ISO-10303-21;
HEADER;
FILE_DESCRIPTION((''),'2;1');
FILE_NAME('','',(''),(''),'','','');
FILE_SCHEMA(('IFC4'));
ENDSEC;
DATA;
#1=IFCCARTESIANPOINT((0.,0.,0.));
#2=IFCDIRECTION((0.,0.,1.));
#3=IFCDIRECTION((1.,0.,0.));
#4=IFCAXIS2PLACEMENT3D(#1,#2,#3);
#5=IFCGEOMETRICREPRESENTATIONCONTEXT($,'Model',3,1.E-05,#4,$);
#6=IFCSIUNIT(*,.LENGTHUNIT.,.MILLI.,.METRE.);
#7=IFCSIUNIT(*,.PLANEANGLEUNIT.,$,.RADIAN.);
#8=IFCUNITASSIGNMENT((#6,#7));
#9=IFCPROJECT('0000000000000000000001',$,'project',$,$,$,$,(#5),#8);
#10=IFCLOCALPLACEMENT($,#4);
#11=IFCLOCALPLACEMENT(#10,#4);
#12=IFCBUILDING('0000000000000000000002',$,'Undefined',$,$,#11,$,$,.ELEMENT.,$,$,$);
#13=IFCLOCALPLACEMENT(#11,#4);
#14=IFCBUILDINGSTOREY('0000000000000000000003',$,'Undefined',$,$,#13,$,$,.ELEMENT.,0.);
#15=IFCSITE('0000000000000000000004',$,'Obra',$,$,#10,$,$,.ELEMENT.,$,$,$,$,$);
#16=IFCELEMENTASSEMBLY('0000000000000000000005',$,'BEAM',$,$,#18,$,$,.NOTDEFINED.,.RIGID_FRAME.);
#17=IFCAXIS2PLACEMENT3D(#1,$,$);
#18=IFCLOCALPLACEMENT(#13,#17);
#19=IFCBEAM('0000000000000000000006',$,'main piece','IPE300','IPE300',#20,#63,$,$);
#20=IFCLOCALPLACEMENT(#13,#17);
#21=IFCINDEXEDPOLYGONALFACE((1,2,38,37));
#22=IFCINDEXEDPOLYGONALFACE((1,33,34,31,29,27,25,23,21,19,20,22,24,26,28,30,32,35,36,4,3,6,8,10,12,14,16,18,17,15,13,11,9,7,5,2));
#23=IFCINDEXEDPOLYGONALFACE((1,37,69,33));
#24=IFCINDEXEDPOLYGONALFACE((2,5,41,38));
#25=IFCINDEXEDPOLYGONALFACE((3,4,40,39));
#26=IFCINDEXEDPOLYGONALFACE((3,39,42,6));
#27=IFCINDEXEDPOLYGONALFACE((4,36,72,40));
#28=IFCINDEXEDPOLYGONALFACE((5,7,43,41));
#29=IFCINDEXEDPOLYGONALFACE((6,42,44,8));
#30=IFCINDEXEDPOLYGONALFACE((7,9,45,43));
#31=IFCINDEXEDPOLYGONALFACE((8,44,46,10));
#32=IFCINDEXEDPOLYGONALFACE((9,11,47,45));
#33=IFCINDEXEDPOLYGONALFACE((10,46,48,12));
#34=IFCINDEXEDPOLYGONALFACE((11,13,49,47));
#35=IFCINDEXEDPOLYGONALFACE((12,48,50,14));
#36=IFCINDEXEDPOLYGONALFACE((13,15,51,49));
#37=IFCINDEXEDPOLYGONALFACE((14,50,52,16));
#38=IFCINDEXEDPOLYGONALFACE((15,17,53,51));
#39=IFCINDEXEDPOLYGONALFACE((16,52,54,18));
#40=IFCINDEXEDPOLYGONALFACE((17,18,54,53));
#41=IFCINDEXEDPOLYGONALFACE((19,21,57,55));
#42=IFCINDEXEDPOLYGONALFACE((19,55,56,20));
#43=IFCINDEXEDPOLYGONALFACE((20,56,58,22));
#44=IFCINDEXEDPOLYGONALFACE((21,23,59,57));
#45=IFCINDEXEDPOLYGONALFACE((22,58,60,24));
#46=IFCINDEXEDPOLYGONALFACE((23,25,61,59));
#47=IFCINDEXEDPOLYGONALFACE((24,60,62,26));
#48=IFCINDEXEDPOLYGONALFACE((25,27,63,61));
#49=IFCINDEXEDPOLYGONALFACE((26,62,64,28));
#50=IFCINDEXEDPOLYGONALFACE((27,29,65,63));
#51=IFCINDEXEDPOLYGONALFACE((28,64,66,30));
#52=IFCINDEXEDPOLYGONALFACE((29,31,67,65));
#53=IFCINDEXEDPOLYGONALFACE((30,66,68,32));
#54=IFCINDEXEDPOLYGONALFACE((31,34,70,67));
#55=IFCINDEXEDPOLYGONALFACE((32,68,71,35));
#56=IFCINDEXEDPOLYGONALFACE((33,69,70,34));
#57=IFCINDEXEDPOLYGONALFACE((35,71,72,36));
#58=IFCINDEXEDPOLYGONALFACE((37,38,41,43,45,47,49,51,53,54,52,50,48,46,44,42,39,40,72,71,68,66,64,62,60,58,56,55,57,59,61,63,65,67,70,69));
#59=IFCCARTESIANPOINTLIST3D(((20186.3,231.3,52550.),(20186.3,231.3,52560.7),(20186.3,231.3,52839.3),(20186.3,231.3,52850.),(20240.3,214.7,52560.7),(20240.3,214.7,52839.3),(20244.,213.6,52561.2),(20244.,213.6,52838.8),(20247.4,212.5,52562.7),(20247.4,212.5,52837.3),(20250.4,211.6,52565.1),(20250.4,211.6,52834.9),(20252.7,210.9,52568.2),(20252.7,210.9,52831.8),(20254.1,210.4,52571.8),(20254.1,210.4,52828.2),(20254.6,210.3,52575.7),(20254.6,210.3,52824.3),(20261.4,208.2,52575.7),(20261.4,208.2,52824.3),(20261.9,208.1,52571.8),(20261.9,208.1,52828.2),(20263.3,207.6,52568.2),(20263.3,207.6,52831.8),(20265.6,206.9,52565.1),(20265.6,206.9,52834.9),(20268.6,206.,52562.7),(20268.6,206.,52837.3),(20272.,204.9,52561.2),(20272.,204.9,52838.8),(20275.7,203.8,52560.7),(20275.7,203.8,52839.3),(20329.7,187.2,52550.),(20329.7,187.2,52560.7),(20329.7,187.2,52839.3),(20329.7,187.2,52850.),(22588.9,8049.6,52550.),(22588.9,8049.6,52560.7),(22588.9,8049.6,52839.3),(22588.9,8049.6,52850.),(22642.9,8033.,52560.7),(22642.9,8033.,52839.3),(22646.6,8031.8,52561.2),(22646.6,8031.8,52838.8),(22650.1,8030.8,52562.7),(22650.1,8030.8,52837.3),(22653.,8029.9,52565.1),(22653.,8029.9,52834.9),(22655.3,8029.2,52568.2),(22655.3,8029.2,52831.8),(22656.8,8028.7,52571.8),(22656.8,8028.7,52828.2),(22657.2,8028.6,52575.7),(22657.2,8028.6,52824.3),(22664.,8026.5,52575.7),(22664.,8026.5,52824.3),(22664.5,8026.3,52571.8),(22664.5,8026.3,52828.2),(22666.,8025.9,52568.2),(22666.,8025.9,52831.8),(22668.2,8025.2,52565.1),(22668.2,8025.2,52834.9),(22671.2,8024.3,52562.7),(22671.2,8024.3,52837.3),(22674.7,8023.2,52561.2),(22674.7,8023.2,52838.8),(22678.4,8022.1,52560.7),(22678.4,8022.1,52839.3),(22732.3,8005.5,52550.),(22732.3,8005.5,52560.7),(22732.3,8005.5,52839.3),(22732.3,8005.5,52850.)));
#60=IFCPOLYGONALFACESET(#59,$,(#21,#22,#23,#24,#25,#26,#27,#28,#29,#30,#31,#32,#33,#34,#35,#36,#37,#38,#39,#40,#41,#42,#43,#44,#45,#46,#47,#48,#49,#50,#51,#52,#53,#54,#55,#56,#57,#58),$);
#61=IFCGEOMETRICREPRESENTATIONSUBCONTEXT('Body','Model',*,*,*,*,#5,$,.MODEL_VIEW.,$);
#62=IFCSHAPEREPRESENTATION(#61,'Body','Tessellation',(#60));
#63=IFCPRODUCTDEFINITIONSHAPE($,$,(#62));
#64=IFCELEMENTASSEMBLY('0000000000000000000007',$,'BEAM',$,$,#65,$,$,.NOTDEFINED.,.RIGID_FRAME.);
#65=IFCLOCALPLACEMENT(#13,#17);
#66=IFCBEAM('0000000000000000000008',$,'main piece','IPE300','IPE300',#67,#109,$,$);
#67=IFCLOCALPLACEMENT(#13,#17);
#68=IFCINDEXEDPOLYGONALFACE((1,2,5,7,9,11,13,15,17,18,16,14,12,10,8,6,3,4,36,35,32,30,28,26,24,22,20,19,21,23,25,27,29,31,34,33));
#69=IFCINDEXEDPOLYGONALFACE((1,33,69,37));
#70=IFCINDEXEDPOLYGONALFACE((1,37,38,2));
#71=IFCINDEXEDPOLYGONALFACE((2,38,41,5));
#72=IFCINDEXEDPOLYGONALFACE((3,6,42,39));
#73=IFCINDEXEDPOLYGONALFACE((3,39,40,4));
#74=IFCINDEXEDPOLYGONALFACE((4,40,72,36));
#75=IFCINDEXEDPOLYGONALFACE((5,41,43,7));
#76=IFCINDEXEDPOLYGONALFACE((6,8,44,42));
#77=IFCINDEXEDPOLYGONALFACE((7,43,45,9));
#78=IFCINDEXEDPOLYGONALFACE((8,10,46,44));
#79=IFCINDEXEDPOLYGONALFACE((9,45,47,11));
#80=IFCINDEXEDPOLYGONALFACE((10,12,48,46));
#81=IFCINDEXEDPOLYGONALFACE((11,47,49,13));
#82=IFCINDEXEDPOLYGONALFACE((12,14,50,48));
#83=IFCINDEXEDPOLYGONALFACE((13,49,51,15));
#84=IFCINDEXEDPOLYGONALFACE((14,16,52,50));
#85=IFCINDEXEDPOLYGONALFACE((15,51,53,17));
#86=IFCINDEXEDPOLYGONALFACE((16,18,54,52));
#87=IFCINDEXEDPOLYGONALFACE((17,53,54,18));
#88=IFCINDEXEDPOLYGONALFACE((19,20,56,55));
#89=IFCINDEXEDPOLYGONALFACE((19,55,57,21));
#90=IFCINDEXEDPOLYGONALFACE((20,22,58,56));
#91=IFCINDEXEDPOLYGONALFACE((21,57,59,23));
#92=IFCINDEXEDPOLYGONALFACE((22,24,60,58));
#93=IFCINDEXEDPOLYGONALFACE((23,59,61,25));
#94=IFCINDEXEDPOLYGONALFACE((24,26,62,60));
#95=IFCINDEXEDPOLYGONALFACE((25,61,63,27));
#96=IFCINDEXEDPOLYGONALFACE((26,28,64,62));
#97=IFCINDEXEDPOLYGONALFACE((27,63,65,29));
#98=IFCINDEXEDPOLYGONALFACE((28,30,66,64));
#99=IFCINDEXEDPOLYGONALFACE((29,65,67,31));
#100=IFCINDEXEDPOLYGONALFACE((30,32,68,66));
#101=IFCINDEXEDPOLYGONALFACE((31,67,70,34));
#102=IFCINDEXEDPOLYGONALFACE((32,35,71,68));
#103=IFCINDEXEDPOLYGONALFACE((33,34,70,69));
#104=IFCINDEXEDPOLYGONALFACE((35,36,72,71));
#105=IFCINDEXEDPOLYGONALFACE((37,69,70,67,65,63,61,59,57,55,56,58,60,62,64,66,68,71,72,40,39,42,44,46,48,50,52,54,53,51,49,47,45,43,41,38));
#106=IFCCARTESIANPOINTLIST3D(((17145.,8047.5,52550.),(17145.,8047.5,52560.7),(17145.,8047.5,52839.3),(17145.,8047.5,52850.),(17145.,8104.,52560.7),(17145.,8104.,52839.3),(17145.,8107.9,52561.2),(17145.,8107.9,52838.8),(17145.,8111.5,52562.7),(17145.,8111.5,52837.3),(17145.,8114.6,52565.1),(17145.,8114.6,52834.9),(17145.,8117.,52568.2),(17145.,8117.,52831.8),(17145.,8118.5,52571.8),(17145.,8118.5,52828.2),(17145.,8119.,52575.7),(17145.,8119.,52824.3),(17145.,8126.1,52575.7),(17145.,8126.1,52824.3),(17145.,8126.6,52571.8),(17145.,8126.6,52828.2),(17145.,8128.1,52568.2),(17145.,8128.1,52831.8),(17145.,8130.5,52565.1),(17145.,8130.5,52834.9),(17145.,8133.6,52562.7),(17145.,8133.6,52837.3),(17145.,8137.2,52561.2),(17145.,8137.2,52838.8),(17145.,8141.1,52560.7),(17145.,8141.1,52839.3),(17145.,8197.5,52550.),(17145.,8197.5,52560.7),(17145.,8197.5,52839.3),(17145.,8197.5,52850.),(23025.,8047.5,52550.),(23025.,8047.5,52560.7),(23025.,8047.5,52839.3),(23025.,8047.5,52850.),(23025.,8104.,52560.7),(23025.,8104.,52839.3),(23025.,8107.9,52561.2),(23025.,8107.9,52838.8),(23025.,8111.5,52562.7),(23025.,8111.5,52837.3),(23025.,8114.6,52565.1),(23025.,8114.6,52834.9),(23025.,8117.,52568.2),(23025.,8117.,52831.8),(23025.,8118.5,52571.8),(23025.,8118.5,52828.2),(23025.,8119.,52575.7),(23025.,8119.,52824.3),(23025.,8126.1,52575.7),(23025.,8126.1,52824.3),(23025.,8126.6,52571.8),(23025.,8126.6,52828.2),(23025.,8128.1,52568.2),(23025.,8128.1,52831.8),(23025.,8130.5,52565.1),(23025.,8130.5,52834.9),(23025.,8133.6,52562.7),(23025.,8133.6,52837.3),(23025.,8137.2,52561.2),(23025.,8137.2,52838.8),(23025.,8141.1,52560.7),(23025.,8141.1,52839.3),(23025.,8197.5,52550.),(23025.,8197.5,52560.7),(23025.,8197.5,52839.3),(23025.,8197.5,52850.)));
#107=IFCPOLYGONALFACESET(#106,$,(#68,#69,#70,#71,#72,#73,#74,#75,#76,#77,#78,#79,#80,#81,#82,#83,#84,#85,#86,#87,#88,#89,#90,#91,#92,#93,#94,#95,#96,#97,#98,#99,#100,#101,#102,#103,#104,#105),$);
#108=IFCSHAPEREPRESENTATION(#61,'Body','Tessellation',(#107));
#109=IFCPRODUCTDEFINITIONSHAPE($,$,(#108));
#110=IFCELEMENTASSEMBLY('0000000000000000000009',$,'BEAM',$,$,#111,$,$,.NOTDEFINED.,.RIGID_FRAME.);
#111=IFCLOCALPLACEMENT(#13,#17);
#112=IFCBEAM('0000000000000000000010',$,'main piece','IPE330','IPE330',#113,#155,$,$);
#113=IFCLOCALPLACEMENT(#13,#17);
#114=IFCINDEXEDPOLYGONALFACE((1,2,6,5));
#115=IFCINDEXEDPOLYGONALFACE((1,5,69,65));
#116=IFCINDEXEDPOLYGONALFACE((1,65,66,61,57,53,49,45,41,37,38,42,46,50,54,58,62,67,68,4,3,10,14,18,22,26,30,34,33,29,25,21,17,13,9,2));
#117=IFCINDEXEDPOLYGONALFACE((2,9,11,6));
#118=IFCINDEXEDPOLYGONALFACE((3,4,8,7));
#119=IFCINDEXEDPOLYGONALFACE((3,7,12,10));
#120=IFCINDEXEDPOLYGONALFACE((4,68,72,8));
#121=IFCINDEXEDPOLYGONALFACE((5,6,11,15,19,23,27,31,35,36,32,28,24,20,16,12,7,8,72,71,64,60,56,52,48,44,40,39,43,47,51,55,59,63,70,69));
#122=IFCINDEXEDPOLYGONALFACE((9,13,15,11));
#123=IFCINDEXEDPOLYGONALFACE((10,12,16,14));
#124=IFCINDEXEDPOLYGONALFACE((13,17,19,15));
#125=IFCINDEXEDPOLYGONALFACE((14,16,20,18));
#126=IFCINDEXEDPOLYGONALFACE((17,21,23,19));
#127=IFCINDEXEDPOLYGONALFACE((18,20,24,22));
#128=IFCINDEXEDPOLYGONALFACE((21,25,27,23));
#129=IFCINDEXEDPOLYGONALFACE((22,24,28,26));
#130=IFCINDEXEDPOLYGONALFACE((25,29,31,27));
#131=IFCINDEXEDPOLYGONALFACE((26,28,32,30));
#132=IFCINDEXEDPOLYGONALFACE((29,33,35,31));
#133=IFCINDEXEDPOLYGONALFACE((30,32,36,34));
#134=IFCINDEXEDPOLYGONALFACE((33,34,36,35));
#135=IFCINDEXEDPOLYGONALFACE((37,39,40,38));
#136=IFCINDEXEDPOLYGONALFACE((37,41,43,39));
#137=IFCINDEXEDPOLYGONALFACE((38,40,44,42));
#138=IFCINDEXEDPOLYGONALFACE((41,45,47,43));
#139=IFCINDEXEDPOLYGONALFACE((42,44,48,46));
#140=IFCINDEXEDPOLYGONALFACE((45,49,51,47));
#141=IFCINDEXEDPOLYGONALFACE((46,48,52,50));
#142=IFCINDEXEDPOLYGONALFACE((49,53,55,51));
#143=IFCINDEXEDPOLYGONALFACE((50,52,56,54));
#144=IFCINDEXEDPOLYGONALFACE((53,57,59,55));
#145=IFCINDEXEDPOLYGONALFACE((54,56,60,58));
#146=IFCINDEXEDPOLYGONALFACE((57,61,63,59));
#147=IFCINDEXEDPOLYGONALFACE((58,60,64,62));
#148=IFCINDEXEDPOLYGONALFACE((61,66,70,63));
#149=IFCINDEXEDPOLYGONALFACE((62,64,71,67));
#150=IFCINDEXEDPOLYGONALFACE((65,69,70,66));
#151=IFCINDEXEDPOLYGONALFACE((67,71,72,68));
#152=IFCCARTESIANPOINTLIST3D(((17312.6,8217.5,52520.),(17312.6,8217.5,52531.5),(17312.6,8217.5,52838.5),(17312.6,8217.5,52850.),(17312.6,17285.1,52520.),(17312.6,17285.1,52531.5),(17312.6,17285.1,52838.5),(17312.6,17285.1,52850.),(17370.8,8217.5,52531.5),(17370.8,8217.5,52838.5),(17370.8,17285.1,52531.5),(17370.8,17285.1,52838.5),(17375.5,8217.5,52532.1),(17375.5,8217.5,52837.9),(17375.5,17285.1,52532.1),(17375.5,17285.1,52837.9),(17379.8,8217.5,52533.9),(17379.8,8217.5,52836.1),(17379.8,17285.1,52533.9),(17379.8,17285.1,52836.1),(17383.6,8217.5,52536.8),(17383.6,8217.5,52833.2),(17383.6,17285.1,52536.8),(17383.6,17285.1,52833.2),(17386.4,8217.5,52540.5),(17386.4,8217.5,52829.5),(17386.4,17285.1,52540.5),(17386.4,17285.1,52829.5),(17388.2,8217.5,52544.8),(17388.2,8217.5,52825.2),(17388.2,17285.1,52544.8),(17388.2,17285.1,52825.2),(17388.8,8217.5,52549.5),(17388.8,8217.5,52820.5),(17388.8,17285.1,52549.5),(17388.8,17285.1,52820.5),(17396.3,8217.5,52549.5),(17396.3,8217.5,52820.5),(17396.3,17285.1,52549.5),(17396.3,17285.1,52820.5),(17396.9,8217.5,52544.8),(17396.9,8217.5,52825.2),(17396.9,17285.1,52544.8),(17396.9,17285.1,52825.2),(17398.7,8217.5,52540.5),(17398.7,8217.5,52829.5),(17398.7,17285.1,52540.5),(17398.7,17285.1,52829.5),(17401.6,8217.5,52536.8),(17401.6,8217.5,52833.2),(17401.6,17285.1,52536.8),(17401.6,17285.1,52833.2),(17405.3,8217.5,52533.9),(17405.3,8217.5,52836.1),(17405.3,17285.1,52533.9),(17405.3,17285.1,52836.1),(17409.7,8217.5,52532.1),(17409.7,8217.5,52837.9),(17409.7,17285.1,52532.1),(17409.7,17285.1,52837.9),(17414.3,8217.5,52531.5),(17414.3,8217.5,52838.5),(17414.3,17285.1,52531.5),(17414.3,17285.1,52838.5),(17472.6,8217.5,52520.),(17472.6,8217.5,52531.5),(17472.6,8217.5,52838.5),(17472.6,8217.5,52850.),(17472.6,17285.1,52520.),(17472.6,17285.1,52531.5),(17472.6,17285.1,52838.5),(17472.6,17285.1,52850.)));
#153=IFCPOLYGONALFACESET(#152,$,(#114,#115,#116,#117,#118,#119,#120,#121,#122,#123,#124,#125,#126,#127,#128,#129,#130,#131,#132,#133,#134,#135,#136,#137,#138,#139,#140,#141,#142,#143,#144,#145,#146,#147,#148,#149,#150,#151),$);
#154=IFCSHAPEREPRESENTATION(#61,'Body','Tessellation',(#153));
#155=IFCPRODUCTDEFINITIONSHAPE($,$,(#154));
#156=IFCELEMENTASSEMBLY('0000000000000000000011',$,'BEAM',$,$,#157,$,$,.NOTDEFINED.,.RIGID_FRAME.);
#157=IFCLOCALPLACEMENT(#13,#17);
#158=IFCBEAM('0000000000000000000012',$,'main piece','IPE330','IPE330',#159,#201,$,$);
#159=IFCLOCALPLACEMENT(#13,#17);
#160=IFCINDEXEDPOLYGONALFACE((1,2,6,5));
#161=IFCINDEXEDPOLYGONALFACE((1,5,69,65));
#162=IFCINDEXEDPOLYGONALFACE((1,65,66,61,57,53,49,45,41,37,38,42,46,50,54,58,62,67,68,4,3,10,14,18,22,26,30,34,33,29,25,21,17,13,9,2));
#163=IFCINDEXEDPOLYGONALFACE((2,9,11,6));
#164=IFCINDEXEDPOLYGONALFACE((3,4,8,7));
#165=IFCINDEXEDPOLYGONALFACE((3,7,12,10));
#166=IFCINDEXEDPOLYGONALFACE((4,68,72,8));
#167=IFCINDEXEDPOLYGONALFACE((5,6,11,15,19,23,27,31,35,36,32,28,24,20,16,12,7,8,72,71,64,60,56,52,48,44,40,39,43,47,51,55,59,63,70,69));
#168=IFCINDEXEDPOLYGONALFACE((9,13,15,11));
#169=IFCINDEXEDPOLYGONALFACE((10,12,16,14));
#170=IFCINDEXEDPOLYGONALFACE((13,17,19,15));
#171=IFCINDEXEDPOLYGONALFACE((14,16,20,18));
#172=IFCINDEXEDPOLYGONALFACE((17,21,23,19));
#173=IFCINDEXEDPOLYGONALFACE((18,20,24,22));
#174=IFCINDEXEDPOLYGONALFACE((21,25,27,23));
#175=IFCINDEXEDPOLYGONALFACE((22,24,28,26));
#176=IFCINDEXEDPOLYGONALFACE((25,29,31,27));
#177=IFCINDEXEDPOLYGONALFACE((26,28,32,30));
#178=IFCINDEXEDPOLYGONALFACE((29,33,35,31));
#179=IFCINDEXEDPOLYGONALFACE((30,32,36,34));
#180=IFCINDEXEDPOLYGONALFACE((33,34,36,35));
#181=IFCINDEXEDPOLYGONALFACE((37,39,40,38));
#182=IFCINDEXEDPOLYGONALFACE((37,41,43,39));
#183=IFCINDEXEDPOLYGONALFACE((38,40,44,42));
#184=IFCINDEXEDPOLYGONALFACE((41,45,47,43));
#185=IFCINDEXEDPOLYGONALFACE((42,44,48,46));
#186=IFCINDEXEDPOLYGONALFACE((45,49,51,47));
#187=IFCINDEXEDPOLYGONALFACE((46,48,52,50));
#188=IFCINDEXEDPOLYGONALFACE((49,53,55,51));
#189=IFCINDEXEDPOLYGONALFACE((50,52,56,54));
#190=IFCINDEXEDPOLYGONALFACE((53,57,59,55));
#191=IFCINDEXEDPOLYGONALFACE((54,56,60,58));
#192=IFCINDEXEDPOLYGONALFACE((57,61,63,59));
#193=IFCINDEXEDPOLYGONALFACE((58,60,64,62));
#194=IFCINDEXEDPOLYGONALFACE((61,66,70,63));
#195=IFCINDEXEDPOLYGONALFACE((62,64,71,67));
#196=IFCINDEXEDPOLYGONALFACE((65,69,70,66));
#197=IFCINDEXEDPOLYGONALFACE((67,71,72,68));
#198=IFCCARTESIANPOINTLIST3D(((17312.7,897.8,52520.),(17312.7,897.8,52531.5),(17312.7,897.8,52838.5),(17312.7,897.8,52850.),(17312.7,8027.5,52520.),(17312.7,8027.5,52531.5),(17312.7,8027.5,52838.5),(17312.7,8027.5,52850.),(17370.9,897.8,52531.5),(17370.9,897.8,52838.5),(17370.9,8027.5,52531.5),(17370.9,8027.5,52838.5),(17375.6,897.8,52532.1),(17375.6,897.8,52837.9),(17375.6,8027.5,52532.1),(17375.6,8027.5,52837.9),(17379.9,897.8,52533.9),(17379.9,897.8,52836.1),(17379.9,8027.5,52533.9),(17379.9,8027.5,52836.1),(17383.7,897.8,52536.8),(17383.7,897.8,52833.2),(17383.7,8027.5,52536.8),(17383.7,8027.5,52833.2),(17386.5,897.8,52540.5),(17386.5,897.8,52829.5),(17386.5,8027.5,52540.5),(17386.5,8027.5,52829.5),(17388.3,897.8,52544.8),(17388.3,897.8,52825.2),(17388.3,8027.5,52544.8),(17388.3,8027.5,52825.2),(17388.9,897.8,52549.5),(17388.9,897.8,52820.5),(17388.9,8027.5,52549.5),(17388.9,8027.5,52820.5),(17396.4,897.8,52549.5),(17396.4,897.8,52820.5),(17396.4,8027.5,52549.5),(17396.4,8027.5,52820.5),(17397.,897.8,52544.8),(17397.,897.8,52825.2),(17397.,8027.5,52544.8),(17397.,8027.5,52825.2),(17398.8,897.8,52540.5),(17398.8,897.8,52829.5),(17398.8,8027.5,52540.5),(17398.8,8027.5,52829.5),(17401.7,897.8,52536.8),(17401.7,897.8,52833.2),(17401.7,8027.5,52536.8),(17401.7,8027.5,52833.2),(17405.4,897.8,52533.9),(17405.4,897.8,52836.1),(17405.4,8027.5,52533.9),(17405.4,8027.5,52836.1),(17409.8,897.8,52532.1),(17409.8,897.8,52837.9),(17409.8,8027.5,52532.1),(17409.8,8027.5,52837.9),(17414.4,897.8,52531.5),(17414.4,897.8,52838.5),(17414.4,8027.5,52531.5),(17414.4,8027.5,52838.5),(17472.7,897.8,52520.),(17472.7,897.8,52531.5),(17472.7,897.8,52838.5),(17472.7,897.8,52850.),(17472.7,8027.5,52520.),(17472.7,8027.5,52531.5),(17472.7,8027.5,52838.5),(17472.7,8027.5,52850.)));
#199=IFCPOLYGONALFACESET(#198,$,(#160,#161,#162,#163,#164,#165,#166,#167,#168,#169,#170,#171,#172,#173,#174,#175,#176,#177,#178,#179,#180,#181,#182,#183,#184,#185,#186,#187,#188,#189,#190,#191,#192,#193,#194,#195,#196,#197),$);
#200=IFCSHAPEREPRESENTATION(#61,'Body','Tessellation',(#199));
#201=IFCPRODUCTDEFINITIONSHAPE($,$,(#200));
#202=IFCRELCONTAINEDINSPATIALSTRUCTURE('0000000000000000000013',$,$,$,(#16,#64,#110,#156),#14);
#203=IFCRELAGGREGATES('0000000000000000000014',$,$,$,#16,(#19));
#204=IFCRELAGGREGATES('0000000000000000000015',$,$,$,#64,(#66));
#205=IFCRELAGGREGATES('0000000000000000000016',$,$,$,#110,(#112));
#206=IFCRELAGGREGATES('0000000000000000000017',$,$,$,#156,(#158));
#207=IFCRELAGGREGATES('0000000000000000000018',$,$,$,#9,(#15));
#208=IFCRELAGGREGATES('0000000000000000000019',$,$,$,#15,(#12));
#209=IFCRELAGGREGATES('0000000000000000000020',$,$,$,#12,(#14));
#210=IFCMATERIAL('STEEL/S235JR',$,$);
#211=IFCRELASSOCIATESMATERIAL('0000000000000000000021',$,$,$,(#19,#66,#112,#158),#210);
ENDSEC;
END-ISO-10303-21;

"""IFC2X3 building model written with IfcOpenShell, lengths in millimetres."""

from ifc_helpers import new_model, si_unit, frame, origin_with_axes, origin_2d_with_axis, place, context, subcontext, project, spatial, i_section, extrude, material, element, aggregate, save


model = new_model("IFC2X3")

# Units and contexts
model_context = context("Model", 3, precision=1e-05, world=origin_with_axes())
body_context = subcontext(model_context, "Body", "Model", "MODEL_VIEW")
ifc_project = project(units=[si_unit("LENGTHUNIT", "METRE", prefix="MILLI"), si_unit("PLANEANGLEUNIT", "RADIAN")], contexts=[model_context])

# Site, building, storey
site_placement = place(None, origin_with_axes())
site = spatial("IfcSite", under=ifc_project, at=site_placement, Name="Obra", CompositionType="ELEMENT")
building_placement = place(site_placement, origin_with_axes())
building = spatial("IfcBuilding", under=site, at=building_placement, Name="Undefined", CompositionType="ELEMENT")
storey_placement = place(building_placement, origin_with_axes())
storey = spatial("IfcBuildingStorey", under=building, at=storey_placement, Name="Undefined", CompositionType="ELEMENT", Elevation=0.0)

# Shared definitions
ifc_material_1 = material(Name="STEEL/S235JR")

# Element assemblies, beams
assembly_1_placement = place(storey_placement, origin_with_axes())
assembly_1 = element("IfcElementAssembly", 1, at=assembly_1_placement, inside=storey, Name="BEAM", AssemblyPlace="NOTDEFINED", PredefinedType="RIGID_FRAME")
beam_1_placement = place(assembly_1_placement, frame((20258.0, 209.2, 52700.0), z_axis=(0.0, 0.0, 1.0), x_axis=(0.293752, 0.955882, 0.0)))
beam_1 = element("IfcBeam", 2, at=beam_1_placement, material=ifc_material_1, Name="main piece", Description="IPE300", ObjectType="IPE300", context=body_context, shape_type="SweptSolid", body=[
    extrude(i_section(OverallWidth=150.0, OverallDepth=300.0, WebThickness=7.1, FlangeThickness=10.7, FilletRadius=15.0, at=origin_2d_with_axis()), frame((8179.1, 0.0, 0.0), z_axis=(-1.0, 0.0, 0.0), x_axis=(0.0, -1.0, 0.0)), (0.0, 0.0, 1.0), 8179.1),
])
aggregate(assembly_1, [beam_1])
assembly_2_placement = place(storey_placement, origin_with_axes())
assembly_2 = element("IfcElementAssembly", 3, at=assembly_2_placement, inside=storey, Name="BEAM", AssemblyPlace="NOTDEFINED", PredefinedType="RIGID_FRAME")
beam_2_placement = place(assembly_2_placement, frame((17145.0, 8122.5, 52700.0), z_axis=(0.0, 0.0, 1.0), x_axis=(1.0, 0.0, 0.0)))
beam_2 = element("IfcBeam", 4, at=beam_2_placement, material=ifc_material_1, Name="main piece", Description="IPE300", ObjectType="IPE300", context=body_context, shape_type="SweptSolid", body=[
    extrude(i_section(OverallWidth=150.0, OverallDepth=300.0, WebThickness=7.1, FlangeThickness=10.7, FilletRadius=15.0, at=origin_2d_with_axis()), frame((5880.0, 0.0, 0.0), z_axis=(-1.0, 0.0, 0.0), x_axis=(0.0, -1.0, 0.0)), (0.0, 0.0, 1.0), 5880.0),
])
aggregate(assembly_2, [beam_2])
assembly_3_placement = place(storey_placement, origin_with_axes())
assembly_3 = element("IfcElementAssembly", 5, at=assembly_3_placement, inside=storey, Name="BEAM", AssemblyPlace="NOTDEFINED", PredefinedType="RIGID_FRAME")
beam_3_placement = place(assembly_3_placement, frame((17392.6, 8217.5, 52685.0), z_axis=(0.0, 0.0, 1.0), x_axis=(0.0, 1.0, 0.0)))
beam_3 = element("IfcBeam", 6, at=beam_3_placement, material=ifc_material_1, Name="main piece", Description="IPE330", ObjectType="IPE330", context=body_context, shape_type="SweptSolid", body=[
    extrude(i_section(OverallWidth=160.0, OverallDepth=330.0, WebThickness=7.5, FlangeThickness=11.5, FilletRadius=18.0, at=origin_2d_with_axis()), frame((9067.6, 0.0, 0.0), z_axis=(-1.0, 0.0, 0.0), x_axis=(0.0, -1.0, 0.0)), (0.0, 0.0, 1.0), 9067.6),
])
aggregate(assembly_3, [beam_3])
assembly_4_placement = place(storey_placement, origin_with_axes())
assembly_4 = element("IfcElementAssembly", 7, at=assembly_4_placement, inside=storey, Name="BEAM", AssemblyPlace="NOTDEFINED", PredefinedType="RIGID_FRAME")
beam_4_placement = place(assembly_4_placement, frame((17392.7, 897.8, 52685.0), z_axis=(0.0, 0.0, 1.0), x_axis=(0.0, 1.0, 0.0)))
beam_4 = element("IfcBeam", 8, at=beam_4_placement, material=ifc_material_1, Name="main piece", Description="IPE330", ObjectType="IPE330", context=body_context, shape_type="SweptSolid", body=[
    extrude(i_section(OverallWidth=160.0, OverallDepth=330.0, WebThickness=7.5, FlangeThickness=11.5, FilletRadius=18.0, at=origin_2d_with_axis()), frame((7129.7, 0.0, 0.0), z_axis=(-1.0, 0.0, 0.0), x_axis=(0.0, -1.0, 0.0)), (0.0, 0.0, 1.0), 7129.7),
])
aggregate(assembly_4, [beam_4])

save(model, "model.ifc")
